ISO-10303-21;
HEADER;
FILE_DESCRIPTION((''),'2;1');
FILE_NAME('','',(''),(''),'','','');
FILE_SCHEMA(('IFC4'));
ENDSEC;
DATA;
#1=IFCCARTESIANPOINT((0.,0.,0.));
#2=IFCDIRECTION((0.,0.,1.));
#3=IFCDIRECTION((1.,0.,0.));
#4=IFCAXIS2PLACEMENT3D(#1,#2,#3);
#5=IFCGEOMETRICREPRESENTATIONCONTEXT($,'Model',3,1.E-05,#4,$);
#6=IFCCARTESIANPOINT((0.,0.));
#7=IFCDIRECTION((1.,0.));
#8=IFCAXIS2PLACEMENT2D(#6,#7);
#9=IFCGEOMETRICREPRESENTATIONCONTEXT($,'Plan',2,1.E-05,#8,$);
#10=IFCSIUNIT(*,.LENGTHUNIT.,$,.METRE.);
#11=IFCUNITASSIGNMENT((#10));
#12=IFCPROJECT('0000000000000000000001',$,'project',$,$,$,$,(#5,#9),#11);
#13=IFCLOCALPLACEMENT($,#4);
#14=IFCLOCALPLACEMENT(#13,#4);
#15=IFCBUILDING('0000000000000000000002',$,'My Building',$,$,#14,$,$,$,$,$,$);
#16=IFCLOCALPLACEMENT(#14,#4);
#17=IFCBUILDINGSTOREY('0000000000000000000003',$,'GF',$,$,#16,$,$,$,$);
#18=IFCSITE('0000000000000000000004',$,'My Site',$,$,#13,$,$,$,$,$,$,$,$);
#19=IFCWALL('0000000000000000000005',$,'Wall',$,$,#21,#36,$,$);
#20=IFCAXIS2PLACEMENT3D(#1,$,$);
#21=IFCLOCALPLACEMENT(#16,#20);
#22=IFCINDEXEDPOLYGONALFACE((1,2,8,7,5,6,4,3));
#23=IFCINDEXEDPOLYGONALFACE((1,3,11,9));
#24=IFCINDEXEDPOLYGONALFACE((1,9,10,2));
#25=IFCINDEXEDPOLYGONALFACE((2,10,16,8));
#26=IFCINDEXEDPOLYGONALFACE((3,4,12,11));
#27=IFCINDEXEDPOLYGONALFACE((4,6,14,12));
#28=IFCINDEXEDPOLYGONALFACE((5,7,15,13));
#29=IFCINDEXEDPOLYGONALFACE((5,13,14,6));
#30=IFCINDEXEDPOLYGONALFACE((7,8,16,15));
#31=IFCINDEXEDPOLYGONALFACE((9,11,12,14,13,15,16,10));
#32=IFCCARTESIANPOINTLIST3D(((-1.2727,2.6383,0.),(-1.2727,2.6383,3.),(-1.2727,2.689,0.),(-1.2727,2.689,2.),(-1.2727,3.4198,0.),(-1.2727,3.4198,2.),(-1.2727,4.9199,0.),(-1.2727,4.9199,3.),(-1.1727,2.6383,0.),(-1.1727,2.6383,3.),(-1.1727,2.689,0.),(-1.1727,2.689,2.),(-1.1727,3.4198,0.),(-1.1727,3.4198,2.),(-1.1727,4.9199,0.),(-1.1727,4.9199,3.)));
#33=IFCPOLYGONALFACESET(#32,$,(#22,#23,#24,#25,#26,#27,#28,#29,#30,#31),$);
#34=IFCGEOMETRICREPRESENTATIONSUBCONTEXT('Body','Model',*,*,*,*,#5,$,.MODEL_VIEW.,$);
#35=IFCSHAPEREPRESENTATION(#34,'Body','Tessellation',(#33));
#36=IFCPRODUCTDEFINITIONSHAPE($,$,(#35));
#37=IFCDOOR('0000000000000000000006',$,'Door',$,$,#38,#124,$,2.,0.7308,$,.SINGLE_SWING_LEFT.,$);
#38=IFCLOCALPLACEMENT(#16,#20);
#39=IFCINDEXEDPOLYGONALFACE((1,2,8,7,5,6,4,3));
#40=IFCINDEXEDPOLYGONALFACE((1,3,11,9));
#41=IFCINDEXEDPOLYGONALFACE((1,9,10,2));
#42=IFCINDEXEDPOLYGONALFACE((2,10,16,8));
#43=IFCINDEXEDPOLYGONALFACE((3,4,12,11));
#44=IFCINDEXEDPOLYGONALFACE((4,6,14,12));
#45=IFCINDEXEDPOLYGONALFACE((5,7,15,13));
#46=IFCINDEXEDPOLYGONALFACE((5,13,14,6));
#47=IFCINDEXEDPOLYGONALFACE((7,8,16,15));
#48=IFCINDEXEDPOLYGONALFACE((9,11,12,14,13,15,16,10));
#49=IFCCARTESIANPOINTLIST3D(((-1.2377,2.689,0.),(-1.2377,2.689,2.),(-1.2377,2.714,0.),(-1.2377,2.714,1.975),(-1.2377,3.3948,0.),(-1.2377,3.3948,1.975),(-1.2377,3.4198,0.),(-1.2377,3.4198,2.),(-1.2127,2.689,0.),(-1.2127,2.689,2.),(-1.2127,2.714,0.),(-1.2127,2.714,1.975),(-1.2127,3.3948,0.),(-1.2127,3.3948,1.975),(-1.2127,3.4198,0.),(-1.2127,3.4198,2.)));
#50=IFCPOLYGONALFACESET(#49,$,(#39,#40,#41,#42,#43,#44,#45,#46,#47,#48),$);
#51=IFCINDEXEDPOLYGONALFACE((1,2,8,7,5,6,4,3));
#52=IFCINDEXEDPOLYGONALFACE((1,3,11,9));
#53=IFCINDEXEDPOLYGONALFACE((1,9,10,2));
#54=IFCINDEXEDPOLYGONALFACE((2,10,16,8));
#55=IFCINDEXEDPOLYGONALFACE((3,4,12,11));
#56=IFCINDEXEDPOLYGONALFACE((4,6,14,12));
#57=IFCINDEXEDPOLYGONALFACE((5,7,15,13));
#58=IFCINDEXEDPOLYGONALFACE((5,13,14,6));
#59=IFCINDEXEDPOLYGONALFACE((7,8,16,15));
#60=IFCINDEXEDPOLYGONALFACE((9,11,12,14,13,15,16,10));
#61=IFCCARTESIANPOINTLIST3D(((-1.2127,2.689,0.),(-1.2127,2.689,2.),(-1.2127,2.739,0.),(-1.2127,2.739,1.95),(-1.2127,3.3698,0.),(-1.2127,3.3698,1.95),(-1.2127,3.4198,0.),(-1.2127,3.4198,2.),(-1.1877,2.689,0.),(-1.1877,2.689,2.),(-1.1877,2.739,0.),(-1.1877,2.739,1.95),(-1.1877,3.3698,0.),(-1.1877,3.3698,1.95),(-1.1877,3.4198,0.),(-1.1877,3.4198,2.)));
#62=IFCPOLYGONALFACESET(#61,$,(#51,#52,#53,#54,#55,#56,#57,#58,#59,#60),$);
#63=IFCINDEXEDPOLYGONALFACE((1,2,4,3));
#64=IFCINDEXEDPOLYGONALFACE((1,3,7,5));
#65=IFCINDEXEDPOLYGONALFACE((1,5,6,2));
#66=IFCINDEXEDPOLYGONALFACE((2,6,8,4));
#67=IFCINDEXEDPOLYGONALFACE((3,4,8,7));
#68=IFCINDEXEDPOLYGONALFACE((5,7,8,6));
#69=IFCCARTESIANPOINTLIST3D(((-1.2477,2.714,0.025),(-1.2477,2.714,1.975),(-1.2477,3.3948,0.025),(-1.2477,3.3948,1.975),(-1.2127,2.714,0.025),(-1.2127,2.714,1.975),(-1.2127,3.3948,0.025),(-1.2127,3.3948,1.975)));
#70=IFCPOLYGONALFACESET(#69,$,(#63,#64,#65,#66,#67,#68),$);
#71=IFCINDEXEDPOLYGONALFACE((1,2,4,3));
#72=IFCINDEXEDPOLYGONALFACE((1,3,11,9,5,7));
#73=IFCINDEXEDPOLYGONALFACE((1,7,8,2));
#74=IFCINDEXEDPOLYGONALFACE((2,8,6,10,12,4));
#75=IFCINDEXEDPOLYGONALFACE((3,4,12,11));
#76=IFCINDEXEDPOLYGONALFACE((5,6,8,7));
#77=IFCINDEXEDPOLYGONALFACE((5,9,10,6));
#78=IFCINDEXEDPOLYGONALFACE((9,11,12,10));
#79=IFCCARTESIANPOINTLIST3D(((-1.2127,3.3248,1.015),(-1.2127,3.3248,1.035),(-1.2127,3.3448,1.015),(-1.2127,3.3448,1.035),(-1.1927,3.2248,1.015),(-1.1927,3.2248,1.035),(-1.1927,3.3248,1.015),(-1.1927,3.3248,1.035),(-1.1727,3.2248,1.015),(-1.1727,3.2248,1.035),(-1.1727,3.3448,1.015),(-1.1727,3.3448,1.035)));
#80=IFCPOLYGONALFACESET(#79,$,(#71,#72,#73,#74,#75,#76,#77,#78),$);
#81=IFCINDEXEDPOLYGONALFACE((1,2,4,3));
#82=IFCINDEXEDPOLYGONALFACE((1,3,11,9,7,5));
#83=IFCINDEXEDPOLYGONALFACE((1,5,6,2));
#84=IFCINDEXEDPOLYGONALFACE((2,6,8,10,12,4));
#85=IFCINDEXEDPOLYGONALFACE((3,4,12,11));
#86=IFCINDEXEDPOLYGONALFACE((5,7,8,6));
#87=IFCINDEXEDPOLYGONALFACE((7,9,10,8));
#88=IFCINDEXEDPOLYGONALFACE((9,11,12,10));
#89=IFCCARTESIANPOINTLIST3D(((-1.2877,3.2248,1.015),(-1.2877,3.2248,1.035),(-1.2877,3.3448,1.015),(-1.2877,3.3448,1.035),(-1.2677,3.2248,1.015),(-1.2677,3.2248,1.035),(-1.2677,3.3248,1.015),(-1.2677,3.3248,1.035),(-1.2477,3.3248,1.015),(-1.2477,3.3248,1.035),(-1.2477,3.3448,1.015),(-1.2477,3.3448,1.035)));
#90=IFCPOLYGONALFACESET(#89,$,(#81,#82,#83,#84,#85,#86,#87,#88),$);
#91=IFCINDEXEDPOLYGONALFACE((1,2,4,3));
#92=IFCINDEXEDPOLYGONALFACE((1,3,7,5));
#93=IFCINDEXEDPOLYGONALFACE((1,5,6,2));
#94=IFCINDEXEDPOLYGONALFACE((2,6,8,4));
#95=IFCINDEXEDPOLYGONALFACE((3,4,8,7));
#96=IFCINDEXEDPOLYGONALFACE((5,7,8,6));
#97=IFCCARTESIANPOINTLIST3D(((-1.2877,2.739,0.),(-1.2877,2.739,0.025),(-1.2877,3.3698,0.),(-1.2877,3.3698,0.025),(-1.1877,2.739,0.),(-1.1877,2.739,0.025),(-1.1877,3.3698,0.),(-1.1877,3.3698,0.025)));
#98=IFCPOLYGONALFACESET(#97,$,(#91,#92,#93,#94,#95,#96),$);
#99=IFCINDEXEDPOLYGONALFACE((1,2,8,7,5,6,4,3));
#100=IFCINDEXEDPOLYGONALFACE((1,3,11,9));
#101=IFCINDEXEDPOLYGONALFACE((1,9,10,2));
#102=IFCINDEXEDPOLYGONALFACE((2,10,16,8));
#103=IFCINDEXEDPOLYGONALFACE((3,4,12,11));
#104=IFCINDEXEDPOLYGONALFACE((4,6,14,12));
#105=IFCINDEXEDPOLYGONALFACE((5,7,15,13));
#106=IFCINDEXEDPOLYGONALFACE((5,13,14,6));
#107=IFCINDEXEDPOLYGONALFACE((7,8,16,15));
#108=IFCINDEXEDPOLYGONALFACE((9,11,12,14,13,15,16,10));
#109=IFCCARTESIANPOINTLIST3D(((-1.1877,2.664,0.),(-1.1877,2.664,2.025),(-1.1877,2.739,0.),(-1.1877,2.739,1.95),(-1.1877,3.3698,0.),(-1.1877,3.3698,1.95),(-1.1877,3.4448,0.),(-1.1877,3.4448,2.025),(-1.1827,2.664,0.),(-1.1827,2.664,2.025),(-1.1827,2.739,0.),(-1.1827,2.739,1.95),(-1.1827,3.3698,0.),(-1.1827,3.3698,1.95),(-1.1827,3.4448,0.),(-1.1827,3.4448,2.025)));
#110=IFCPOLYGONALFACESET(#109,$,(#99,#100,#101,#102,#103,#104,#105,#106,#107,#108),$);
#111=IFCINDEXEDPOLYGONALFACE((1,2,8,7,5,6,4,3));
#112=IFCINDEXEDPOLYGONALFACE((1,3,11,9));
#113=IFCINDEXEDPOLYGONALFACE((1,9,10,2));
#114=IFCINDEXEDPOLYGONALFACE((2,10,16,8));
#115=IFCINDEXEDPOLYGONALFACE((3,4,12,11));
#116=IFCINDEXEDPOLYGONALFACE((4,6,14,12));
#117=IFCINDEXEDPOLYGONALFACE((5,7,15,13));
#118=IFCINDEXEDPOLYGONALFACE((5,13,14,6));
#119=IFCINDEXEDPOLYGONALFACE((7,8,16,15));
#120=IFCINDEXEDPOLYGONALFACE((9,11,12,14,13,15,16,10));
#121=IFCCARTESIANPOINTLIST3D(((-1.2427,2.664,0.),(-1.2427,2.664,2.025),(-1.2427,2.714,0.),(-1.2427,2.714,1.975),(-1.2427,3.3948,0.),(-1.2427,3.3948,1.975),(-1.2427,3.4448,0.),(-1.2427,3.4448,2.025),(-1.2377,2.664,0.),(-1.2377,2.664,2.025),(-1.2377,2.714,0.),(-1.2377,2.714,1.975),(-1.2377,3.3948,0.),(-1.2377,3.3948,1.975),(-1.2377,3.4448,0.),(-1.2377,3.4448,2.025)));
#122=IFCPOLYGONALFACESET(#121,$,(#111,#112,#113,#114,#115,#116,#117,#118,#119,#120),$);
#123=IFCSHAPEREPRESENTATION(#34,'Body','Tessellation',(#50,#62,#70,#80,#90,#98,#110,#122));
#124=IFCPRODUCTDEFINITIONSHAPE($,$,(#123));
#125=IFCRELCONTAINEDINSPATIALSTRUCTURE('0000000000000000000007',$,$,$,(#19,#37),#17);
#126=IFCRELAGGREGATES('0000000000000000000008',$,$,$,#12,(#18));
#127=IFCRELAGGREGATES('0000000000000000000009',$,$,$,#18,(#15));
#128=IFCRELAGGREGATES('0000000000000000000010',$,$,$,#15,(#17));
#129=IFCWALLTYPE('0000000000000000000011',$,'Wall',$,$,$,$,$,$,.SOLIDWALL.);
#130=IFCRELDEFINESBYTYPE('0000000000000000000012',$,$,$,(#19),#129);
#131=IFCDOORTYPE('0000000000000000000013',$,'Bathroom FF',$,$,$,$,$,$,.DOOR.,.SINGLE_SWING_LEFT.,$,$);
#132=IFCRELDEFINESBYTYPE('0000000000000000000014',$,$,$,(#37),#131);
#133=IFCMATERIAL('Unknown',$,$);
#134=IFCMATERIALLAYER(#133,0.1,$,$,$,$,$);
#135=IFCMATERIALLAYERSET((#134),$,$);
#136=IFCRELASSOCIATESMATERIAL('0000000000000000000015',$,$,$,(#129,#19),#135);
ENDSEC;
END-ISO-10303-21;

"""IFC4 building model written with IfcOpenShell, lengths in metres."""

from ifc_helpers import new_model, entity, si_unit, frame, origin_with_axes, origin_2d_with_axis, place, context, subcontext, project, spatial, line, indexed_curve, outline, extrude, shape, source, transform, mapped, material, layer, layer_set, layer_usage, type_object, type_shapes, element, fill, save


model = new_model("IFC4")

# Units and contexts
model_context = context("Model", 3, precision=1e-05, world=origin_with_axes())
plan_context = context("Plan", 2, precision=1e-05, world=origin_2d_with_axis())
body_context_1 = subcontext(model_context, "Body", "Model", "MODEL_VIEW")
body_context_2 = subcontext(plan_context, "Body", "Plan", "PLAN_VIEW")
ifc_project = project(units=[si_unit("LENGTHUNIT", "METRE")], contexts=[model_context, plan_context])

# Site, building, storey
site_placement = place(None, origin_with_axes())
site = spatial("IfcSite", under=ifc_project, at=site_placement, Name="My Site")
building_placement = place(site_placement, origin_with_axes())
building = spatial("IfcBuilding", under=site, at=building_placement, Name="My Building")
storey_placement = place(building_placement, origin_with_axes())
storey = spatial("IfcBuildingStorey", under=building, at=storey_placement, Name="GF")

# Shared definitions
ifc_material = material(Name="Unknown")

# Shared definitions
ifc_layer_1 = layer(ifc_material, 0.1)
ifc_layer_set_1 = layer_set([ifc_layer_1])
wall_type = type_object("IfcWallType", Name="Wall", PredefinedType="SOLIDWALL", material=ifc_layer_set_1)

# Wall, opening, door
ifc_layer_usage_1 = layer_usage(ifc_layer_set_1, "AXIS2", "POSITIVE", 0.0)
wall_1_placement = place(storey_placement, frame((-1.1727, 2.6383, 0.0), z_axis=(0.0, 0.0, 1.0), x_axis=(0.0, 1.0, 0.0)))
wall_1 = element("IfcWall", 1, at=wall_1_placement, inside=storey, type_object=wall_type, material=ifc_layer_usage_1, Name="Wall", context=body_context_1, shape_type="SweptSolid", body=[
    extrude(outline(indexed_curve([(0.0, 0.0), (0.0, 0.1), (2.2816, 0.1), (2.2816, 0.0)], segments=[line(1, 2, 3, 4, 1)])), origin_with_axes(), (0.0, 0.0, 1.0), 3.0),
])
shared_shape_1 = source(origin_with_axes(), body_context_1, "Body", "SweptSolid", [
    extrude(outline(indexed_curve([(0.0, 0.0), (0.7308, 0.0), (0.7308, 2.0), (0.0, 2.0)], segments=[line(1, 2, 3, 4, 1)])), frame((0.0, -0.6, 0.0), z_axis=(0.0, -1.0, 0.0), x_axis=(1.0, 0.0, 0.0)), (0.0, 0.0, -1.0), 1.2),
])
opening_1_placement = place(wall_1_placement, frame((0.0507, 0.015, 0.0), z_axis=(0.0, 0.0, 1.0), x_axis=(1.0, 0.0, 0.0)))
opening_1 = element("IfcOpeningElement", 2, at=opening_1_placement, cuts=wall_1, PredefinedType="OPENING", context=body_context_1, shape_type="MappedRepresentation", body=[
    mapped(shared_shape_1, transform((0.0, 0.0, 0.0), x_axis=(1.0, 0.0, 0.0), y_axis=(0.0, 1.0, 0.0), z_axis=(0.0, 0.0, 1.0), scale=1.0)),
])
door_type_1 = type_object("IfcDoorType", Name="Bathroom FF", OperationType="SINGLE_SWING_LEFT", PredefinedType="DOOR")
shared_shape_2 = source(origin_with_axes(), body_context_1, "Body", "SweptSolid", [
    extrude(outline(indexed_curve([(0.0, 0.0), (0.0, 2.0), (0.7308, 2.0), (0.7308, 0.0), (0.7058, 0.0), (0.7058, 1.975), (0.025, 1.975), (0.025, 0.0)], segments=[line(1, 2, 3, 4, 5, 6, 7, 8, 1)])), frame((0.0, 0.025, 0.0), z_axis=(0.0, -1.0, 0.0), x_axis=(1.0, 0.0, 0.0)), (0.0, 0.0, -1.0), 0.025),
    extrude(outline(indexed_curve([(0.0, 0.0), (0.0, 2.0), (0.7308, 2.0), (0.7308, 0.0), (0.6808, 0.0), (0.6808, 1.95), (0.05, 1.95), (0.05, 0.0)], segments=[line(1, 2, 3, 4, 5, 6, 7, 8, 1)])), frame((0.0, 0.0, 0.0), z_axis=(0.0, -1.0, 0.0), x_axis=(1.0, 0.0, 0.0)), (0.0, 0.0, -1.0), 0.025),
    extrude(outline(indexed_curve([(0.0, 0.0), (0.6808, 0.0), (0.6808, 0.035), (0.0, 0.035)], segments=[line(1, 2, 3, 4, 1)])), frame((0.025, 0.025, 0.025), z_axis=(0.0, 0.0, 1.0), x_axis=(1.0, 0.0, 0.0)), (0.0, 0.0, 1.0), 1.95),
    extrude(outline(indexed_curve([(0.0, 0.0), (0.0, -0.04), (-0.12, -0.04), (-0.12, -0.02), (-0.02, -0.02), (-0.02, 0.0)], segments=[line(1, 2, 3, 4, 5, 6, 1)])), frame((0.6558, 0.025, 1.015), z_axis=(0.0, 0.0, 1.0), x_axis=(1.0, 0.0, 0.0)), (0.0, 0.0, 1.0), 0.02),
    extrude(outline(indexed_curve([(0.0, 0.0), (0.0, 0.04), (-0.12, 0.04), (-0.12, 0.02), (-0.02, 0.02), (-0.02, 0.0)], segments=[line(1, 2, 3, 4, 5, 6, 1)])), frame((0.6558, 0.06, 1.015), z_axis=(0.0, 0.0, 1.0), x_axis=(1.0, 0.0, 0.0)), (0.0, 0.0, 1.0), 0.02),
    extrude(outline(indexed_curve([(0.0, 0.0), (0.6308, 0.0), (0.6308, 0.1), (0.0, 0.1)], segments=[line(1, 2, 3, 4, 1)])), frame((0.05, 0.0, 0.0), z_axis=(0.0, 0.0, 1.0), x_axis=(1.0, 0.0, 0.0)), (0.0, 0.0, 1.0), 0.025),
    extrude(outline(indexed_curve([(0.0, 0.0), (0.0, 2.025), (0.7808, 2.025), (0.7808, 0.0), (0.7058, 0.0), (0.7058, 1.95), (0.075, 1.95), (0.075, 0.0)], segments=[line(1, 2, 3, 4, 5, 6, 7, 8, 1)])), frame((-0.025, -0.005, 0.0), z_axis=(0.0, -1.0, 0.0), x_axis=(1.0, 0.0, 0.0)), (0.0, 0.0, -1.0), 0.005),
    extrude(outline(indexed_curve([(0.0, 0.0), (0.0, 2.025), (0.7808, 2.025), (0.7808, 0.0), (0.7308, 0.0), (0.7308, 1.975), (0.05, 1.975), (0.05, 0.0)], segments=[line(1, 2, 3, 4, 5, 6, 7, 8, 1)])), frame((-0.025, 0.05, 0.0), z_axis=(0.0, -1.0, 0.0), x_axis=(1.0, 0.0, 0.0)), (0.0, 0.0, -1.0), 0.005),
])
shared_shape_3 = source(origin_with_axes(), body_context_2, "Body", "Curve2D", [
    entity("IfcIndexedPolyCurve", entity("IfcCartesianPointList2D", [[0.0, 0.0], [0.0, 0.05], [0.025, 0.05], [0.025, 0.025], [0.05, 0.025], [0.05, 0.0]]), [entity("IfcLineIndex", [1, 2, 3, 4, 5, 6, 1])]),
    entity("IfcIndexedPolyCurve", entity("IfcCartesianPointList2D", [[0.7308, 0.0], [0.7308, 0.05], [0.7058, 0.05], [0.7058, 0.025], [0.6808, 0.025], [0.6808, 0.0]]), [entity("IfcLineIndex", [1, 2, 3, 4, 5, 6, 1])]),
    entity("IfcTrimmedCurve", entity("IfcEllipse", entity("IfcAxis2Placement2D", entity("IfcCartesianPoint", [0.06, 0.05]), entity("IfcDirection", [1.0, 0.0])), 0.6458, 0.6808), [entity("IfcCartesianPoint", [0.7058, 0.05])], [entity("IfcCartesianPoint", [0.06, 0.7308])], True, "CARTESIAN"),
    entity("IfcIndexedPolyCurve", entity("IfcCartesianPointList2D", [[0.025, 0.05], [0.06, 0.05], [0.06, 0.7308], [0.025, 0.7308]]), [entity("IfcLineIndex", [1, 2, 3, 4, 1])]),
])
type_shapes(door_type_1, [shared_shape_2, shared_shape_3])
door_1_placement = place(opening_1_placement, frame((0.0, 0.0, 0.0), z_axis=(0.0, 0.0, 1.0), x_axis=(1.0, 0.0, 0.0)))
door_1 = element("IfcDoor", 3, at=door_1_placement, inside=storey, type_object=door_type_1, Name="Door", OperationType="SINGLE_SWING_LEFT", OverallHeight=2.0, OverallWidth=0.7308, shapes=[
    shape(body_context_1, "Body", "MappedRepresentation", [mapped(shared_shape_2, transform((0.0, 0.0, 0.0), x_axis=(1.0, 0.0, 0.0), y_axis=(0.0, 1.0, 0.0), z_axis=(0.0, 0.0, 1.0), scale=1.0))]),
    shape(body_context_2, "Body", "MappedRepresentation", [mapped(shared_shape_3, transform((0.0, 0.0, 0.0), x_axis=(1.0, 0.0, 0.0), y_axis=(0.0, 1.0, 0.0), z_axis=(0.0, 0.0, 1.0), scale=1.0))]),
])
fill(opening_1, door_1)

save(model, "model.ifc")
